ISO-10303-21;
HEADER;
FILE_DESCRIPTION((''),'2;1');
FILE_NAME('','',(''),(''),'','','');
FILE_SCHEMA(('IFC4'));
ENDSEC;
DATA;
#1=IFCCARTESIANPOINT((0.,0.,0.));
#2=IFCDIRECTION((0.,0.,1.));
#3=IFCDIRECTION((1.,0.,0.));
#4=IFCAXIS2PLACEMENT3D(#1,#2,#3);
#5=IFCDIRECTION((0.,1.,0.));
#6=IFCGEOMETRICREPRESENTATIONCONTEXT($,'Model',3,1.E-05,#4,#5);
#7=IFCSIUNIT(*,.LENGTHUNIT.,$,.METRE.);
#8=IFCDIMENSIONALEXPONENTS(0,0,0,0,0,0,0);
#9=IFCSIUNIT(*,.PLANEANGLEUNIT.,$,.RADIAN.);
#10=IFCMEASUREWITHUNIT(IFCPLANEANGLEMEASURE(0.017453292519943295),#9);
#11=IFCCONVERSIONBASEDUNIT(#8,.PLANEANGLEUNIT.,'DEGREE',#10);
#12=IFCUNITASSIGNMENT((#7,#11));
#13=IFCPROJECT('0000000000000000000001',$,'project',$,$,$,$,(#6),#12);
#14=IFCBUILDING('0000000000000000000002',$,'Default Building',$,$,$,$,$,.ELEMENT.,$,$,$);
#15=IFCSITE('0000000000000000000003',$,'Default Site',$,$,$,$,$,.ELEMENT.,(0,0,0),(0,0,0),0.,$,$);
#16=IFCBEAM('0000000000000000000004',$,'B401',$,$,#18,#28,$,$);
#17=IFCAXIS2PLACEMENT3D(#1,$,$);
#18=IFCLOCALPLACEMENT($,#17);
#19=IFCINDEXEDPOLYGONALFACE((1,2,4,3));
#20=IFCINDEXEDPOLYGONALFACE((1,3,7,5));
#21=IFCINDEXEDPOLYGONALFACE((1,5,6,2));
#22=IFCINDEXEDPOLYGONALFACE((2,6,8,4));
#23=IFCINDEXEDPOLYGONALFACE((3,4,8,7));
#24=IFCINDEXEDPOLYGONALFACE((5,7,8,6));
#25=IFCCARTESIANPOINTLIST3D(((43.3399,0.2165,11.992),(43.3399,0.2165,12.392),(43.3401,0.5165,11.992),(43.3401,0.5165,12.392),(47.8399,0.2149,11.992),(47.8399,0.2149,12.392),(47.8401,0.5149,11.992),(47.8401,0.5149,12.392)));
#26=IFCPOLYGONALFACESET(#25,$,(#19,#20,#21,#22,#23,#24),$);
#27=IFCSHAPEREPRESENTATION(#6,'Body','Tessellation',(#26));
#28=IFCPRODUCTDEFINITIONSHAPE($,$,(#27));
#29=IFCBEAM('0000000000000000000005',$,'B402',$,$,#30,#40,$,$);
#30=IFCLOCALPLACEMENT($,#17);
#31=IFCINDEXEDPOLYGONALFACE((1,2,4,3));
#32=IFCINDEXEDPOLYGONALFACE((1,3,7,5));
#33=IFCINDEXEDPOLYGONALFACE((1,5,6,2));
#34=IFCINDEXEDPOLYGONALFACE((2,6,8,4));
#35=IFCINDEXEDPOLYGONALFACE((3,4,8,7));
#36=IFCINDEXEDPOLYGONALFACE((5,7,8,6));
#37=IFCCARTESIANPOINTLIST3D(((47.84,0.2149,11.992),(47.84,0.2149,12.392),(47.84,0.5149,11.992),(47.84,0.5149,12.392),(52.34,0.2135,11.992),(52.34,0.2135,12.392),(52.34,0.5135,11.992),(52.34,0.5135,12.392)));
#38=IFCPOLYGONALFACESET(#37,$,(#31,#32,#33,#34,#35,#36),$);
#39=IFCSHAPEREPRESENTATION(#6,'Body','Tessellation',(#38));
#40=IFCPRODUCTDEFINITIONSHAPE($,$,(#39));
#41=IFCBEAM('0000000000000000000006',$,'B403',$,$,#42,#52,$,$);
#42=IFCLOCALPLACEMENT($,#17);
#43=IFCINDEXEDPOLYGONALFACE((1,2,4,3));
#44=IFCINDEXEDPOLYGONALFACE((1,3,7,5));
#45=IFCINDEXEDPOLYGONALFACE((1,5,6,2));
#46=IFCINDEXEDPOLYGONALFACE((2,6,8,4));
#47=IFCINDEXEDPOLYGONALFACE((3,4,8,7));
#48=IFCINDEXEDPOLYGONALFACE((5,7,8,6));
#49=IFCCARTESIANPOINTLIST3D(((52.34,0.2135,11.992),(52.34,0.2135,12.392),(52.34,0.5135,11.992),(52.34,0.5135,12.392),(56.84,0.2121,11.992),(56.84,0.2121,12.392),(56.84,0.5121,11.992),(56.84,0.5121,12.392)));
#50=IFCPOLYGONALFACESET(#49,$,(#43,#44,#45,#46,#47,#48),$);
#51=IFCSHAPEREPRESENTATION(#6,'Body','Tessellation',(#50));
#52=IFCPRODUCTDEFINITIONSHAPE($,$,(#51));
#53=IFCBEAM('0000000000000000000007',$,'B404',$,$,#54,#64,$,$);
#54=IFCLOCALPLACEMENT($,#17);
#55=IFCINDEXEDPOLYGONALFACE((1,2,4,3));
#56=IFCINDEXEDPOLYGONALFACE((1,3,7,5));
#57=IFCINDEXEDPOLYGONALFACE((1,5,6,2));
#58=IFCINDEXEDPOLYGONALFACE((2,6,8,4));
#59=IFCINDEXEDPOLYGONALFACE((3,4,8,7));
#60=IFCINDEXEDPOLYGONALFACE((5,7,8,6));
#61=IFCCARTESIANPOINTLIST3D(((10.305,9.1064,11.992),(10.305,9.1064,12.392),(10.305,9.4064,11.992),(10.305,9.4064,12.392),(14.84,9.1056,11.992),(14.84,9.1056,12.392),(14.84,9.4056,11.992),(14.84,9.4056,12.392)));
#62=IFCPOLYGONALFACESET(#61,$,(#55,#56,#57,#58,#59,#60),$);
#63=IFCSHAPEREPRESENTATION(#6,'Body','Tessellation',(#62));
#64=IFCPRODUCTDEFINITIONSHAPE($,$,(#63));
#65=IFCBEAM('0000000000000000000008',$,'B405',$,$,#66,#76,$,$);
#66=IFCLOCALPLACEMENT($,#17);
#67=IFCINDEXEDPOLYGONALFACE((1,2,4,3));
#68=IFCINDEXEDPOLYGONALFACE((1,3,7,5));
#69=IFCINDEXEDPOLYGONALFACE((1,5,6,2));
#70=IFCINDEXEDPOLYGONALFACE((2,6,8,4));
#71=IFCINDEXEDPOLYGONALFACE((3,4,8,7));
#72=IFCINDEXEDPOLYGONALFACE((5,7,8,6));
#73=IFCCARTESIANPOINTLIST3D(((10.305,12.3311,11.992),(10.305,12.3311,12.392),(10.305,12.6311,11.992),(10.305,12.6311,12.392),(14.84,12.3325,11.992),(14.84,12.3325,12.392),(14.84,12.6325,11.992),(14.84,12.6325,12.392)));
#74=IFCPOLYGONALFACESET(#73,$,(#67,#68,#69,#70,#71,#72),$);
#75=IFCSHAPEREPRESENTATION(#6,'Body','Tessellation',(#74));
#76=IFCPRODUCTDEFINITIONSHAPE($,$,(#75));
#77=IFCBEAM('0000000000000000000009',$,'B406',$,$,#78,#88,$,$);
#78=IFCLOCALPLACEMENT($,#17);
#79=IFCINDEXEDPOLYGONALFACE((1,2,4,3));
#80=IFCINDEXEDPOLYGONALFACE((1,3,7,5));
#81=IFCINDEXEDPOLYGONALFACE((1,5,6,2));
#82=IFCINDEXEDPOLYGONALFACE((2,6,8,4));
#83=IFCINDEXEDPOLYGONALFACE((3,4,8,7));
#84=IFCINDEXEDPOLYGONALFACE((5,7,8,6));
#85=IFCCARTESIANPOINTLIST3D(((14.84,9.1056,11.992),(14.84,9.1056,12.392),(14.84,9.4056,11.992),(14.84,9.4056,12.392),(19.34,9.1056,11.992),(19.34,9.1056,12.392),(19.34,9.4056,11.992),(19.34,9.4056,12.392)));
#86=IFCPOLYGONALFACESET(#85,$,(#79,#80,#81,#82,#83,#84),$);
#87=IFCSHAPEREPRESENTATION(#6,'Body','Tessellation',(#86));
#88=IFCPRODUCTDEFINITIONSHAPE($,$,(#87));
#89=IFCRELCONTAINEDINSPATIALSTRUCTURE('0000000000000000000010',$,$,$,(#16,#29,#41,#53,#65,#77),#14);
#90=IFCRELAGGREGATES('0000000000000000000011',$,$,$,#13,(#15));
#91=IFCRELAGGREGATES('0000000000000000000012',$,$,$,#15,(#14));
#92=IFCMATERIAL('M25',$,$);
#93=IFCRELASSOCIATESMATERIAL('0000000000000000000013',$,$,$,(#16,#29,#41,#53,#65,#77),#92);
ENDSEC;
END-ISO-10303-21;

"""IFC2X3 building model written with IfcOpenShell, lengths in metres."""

from ifc_helpers import new_model, entity, si_unit, converted_unit, direction, frame, frame_2d, origin_with_axes, place, context, project, spatial, rectangle, extrude, material, element, save


model = new_model("IFC2X3")

# Units and contexts
model_context = context("Model", 3, precision=1e-05, world=origin_with_axes(), true_north=direction((0.0, 1.0, 0.0)))
ifc_project = project(units=[si_unit("LENGTHUNIT", "METRE"), converted_unit("PLANEANGLEUNIT", "DEGREE", entity("IfcPlaneAngleMeasure", 0.017453292519943295), si_unit("PLANEANGLEUNIT", "RADIAN"), dimensions=[0, 0, 0, 0, 0, 0, 0])], contexts=[model_context])

# Site, building
site = spatial("IfcSite", under=ifc_project, Name="Default Site", CompositionType="ELEMENT", RefLatitude=(0, 0, 0), RefLongitude=(0, 0, 0), RefElevation=0.0)
building = spatial("IfcBuilding", under=site, Name="Default Building", CompositionType="ELEMENT")

# Beams
ifc_material = material(Name="M25")
placement = place(None, origin_with_axes())
element("IfcBeam", 1, at=placement, inside=building, material=ifc_material, Name="B401", context=model_context, shape_type="SweptSolid", body=[
    extrude(rectangle(XDim=0.3, YDim=0.4, at=frame_2d((0.0, 0.0), x_axis=(0.0, 1.0, 0.0))), frame((43.34, 0.3665, 12.192), z_axis=(1.0, -0.000358, 0.0), x_axis=(0.0, 0.0, -1.0)), (0.0, 0.0, 1.0), 4.5),
])
element("IfcBeam", 2, at=placement, inside=building, material=ifc_material, Name="B402", context=model_context, shape_type="SweptSolid", body=[
    extrude(rectangle(XDim=0.3, YDim=0.4, at=frame_2d((0.0, 0.0), x_axis=(0.0, 1.0, 0.0))), frame((47.84, 0.3649, 12.192), z_axis=(1.0, -0.000297, 0.0), x_axis=(0.0, 0.0, -1.0)), (0.0, 0.0, 1.0), 4.5),
])
element("IfcBeam", 3, at=placement, inside=building, material=ifc_material, Name="B403", context=model_context, shape_type="SweptSolid", body=[
    extrude(rectangle(XDim=0.3, YDim=0.4, at=frame_2d((0.0, 0.0), x_axis=(0.0, 1.0, 0.0))), frame((52.34, 0.3635, 12.192), z_axis=(1.0, -0.000311, 0.0), x_axis=(0.0, 0.0, -1.0)), (0.0, 0.0, 1.0), 4.5),
])
element("IfcBeam", 4, at=placement, inside=building, material=ifc_material, Name="B404", context=model_context, shape_type="SweptSolid", body=[
    extrude(rectangle(XDim=0.3, YDim=0.4, at=frame_2d((0.0, 0.0), x_axis=(0.0, 1.0, 0.0))), frame((10.305, 9.2564, 12.192), z_axis=(1.0, -0.000182, 0.0), x_axis=(0.0, 0.0, -1.0)), (0.0, 0.0, 1.0), 4.535),
])
element("IfcBeam", 5, at=placement, inside=building, material=ifc_material, Name="B405", context=model_context, shape_type="SweptSolid", body=[
    extrude(rectangle(XDim=0.3, YDim=0.4, at=frame_2d((0.0, 0.0), x_axis=(0.0, 1.0, 0.0))), frame((10.305, 12.4811, 12.192), z_axis=(1.0, 0.000301, 0.0), x_axis=(0.0, 0.0, -1.0)), (0.0, 0.0, 1.0), 4.535),
])
element("IfcBeam", 6, at=placement, inside=building, material=ifc_material, Name="B406", context=model_context, shape_type="SweptSolid", body=[
    extrude(rectangle(XDim=0.3, YDim=0.4, at=frame_2d((0.0, 0.0), x_axis=(0.0, 1.0, 0.0))), frame((14.84, 9.2556, 12.192), z_axis=(1.0, 0.000013, 0.0), x_axis=(0.0, 0.0, -1.0)), (0.0, 0.0, 1.0), 4.5),
])

save(model, "model.ifc")
